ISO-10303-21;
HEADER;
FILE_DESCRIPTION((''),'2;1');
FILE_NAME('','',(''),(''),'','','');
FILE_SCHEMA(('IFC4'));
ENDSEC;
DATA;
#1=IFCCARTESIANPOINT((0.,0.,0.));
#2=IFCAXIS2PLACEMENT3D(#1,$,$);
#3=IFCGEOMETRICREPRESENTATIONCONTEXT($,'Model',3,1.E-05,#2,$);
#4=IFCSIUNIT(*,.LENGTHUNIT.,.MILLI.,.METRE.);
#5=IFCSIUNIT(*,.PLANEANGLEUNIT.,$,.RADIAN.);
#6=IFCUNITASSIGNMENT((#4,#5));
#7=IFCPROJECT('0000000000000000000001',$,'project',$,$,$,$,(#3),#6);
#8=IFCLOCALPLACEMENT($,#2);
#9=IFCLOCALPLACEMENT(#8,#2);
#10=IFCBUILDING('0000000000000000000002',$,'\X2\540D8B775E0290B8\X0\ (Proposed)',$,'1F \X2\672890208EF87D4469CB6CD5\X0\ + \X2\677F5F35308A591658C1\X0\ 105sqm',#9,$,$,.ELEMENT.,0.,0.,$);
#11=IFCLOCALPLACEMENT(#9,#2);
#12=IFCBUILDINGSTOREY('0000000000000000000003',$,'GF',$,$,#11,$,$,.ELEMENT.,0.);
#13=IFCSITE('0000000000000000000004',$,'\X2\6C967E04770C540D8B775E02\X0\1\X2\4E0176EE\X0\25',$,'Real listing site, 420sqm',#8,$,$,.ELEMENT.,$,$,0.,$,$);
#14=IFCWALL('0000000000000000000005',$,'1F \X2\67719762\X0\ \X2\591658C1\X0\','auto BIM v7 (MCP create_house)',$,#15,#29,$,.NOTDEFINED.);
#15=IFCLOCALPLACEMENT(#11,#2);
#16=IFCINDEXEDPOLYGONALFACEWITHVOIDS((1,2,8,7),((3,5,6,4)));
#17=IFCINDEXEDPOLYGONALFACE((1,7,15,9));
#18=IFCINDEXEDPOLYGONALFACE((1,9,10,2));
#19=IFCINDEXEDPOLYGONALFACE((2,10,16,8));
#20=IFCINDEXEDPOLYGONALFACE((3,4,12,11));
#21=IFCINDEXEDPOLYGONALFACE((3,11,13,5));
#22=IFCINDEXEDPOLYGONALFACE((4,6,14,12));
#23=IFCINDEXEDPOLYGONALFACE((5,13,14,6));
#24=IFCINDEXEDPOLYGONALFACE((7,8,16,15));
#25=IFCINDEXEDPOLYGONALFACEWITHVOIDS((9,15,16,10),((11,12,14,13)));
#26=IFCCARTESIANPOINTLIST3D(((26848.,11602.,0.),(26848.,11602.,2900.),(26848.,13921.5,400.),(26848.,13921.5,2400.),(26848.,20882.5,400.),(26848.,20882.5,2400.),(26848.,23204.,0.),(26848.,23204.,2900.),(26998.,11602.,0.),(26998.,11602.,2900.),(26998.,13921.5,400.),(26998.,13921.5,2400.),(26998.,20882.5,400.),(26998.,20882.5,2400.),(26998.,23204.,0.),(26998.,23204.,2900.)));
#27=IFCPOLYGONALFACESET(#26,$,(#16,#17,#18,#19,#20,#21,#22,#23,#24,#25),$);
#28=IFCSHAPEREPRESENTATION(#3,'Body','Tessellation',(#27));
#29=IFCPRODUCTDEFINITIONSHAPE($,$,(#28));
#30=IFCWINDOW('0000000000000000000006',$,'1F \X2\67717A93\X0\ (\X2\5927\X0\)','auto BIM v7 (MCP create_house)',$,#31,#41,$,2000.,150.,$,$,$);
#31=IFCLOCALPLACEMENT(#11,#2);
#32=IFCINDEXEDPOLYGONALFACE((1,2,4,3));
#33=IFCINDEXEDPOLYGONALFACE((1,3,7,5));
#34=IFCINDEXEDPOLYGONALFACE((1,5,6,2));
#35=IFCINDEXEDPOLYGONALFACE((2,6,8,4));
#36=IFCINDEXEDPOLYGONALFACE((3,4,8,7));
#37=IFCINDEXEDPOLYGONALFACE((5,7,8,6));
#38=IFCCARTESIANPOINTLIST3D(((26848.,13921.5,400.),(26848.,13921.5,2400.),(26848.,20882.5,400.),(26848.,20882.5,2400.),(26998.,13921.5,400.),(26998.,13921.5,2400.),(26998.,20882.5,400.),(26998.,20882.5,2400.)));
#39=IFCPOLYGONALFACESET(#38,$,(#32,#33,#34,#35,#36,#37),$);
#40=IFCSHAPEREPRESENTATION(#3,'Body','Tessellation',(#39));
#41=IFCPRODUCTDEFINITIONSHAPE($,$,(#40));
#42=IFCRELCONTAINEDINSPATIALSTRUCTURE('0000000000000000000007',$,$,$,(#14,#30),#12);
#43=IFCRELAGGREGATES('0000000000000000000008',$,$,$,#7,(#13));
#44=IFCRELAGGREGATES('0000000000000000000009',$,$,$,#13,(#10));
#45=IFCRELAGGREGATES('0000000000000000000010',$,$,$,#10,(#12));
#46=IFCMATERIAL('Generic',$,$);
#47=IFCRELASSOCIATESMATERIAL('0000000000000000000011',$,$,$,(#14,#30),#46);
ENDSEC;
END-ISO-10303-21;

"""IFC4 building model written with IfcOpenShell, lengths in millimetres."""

from ifc_helpers import new_model, si_unit, frame, frame_2d, origin, place, context, project, spatial, rectangle, extrude, material, element, fill, save


model = new_model("IFC4")

# Units and contexts
model_context = context("Model", 3, precision=1e-05, world=origin())
ifc_project = project(units=[si_unit("LENGTHUNIT", "METRE", prefix="MILLI"), si_unit("PLANEANGLEUNIT", "RADIAN")], contexts=[model_context])

# Site, building, storey
site_placement = place(None, origin())
site = spatial("IfcSite", under=ifc_project, at=site_placement, Name="沖縄県名護市1丁目25", ObjectType="Real listing site, 420sqm", CompositionType="ELEMENT", RefElevation=0.0)
building_placement = place(site_placement, origin())
building = spatial("IfcBuilding", under=site, at=building_placement, Name="名護市邸 (Proposed)", ObjectType="1F 木造軸組構法 + 板張り外壁 105sqm", CompositionType="ELEMENT", ElevationOfRefHeight=0.0, ElevationOfTerrain=0.0)
storey_placement = place(building_placement, origin())
storey = spatial("IfcBuildingStorey", under=building, at=storey_placement, Name="GF", CompositionType="ELEMENT", Elevation=0.0)

# Shared definitions
ifc_material = material(Name="Generic")

# Wall, opening, window
wall_1_placement = place(storey_placement, frame((13424.0, 5801.0, 0.0)))
wall_1 = element("IfcWall", 1, at=wall_1_placement, inside=storey, material=ifc_material, Name="1F 東面 外壁", Description="auto BIM v7 (MCP create_house)", PredefinedType="NOTDEFINED", context=model_context, shape_type="SweptSolid", body=[
    extrude(rectangle(XDim=150.0, YDim=11602.0, at=frame_2d((75.0, 5801.0))), frame((13424.0, 5801.0, 0.0)), (0.0, 0.0, 1.0), 2900.0),
])
opening_1_placement = place(storey_placement, frame((13424.0, 6961.0, 200.0)))
opening_1 = element("IfcOpeningElement", 2, at=opening_1_placement, cuts=wall_1, PredefinedType="NOTDEFINED", context=model_context, shape_type="SweptSolid", body=[
    extrude(rectangle(XDim=150.0, YDim=6961.0, at=frame_2d((75.0, 3480.0))), frame((13424.0, 6961.0, 200.0)), (0.0, 0.0, 1.0), 2000.0),
])
window_1_placement = place(storey_placement, frame((13424.0, 6961.0, 200.0)))
window_1 = element("IfcWindow", 3, at=window_1_placement, inside=storey, material=ifc_material, Name="1F 東窓 (大)", Description="auto BIM v7 (MCP create_house)", OverallHeight=2000.0, OverallWidth=150.0, context=model_context, shape_type="SweptSolid", body=[
    extrude(rectangle(XDim=150.0, YDim=6961.0, at=frame_2d((75.0, 3480.0))), frame((13424.0, 6961.0, 200.0)), (0.0, 0.0, 1.0), 2000.0),
])
fill(opening_1, window_1)

save(model, "model.ifc")
